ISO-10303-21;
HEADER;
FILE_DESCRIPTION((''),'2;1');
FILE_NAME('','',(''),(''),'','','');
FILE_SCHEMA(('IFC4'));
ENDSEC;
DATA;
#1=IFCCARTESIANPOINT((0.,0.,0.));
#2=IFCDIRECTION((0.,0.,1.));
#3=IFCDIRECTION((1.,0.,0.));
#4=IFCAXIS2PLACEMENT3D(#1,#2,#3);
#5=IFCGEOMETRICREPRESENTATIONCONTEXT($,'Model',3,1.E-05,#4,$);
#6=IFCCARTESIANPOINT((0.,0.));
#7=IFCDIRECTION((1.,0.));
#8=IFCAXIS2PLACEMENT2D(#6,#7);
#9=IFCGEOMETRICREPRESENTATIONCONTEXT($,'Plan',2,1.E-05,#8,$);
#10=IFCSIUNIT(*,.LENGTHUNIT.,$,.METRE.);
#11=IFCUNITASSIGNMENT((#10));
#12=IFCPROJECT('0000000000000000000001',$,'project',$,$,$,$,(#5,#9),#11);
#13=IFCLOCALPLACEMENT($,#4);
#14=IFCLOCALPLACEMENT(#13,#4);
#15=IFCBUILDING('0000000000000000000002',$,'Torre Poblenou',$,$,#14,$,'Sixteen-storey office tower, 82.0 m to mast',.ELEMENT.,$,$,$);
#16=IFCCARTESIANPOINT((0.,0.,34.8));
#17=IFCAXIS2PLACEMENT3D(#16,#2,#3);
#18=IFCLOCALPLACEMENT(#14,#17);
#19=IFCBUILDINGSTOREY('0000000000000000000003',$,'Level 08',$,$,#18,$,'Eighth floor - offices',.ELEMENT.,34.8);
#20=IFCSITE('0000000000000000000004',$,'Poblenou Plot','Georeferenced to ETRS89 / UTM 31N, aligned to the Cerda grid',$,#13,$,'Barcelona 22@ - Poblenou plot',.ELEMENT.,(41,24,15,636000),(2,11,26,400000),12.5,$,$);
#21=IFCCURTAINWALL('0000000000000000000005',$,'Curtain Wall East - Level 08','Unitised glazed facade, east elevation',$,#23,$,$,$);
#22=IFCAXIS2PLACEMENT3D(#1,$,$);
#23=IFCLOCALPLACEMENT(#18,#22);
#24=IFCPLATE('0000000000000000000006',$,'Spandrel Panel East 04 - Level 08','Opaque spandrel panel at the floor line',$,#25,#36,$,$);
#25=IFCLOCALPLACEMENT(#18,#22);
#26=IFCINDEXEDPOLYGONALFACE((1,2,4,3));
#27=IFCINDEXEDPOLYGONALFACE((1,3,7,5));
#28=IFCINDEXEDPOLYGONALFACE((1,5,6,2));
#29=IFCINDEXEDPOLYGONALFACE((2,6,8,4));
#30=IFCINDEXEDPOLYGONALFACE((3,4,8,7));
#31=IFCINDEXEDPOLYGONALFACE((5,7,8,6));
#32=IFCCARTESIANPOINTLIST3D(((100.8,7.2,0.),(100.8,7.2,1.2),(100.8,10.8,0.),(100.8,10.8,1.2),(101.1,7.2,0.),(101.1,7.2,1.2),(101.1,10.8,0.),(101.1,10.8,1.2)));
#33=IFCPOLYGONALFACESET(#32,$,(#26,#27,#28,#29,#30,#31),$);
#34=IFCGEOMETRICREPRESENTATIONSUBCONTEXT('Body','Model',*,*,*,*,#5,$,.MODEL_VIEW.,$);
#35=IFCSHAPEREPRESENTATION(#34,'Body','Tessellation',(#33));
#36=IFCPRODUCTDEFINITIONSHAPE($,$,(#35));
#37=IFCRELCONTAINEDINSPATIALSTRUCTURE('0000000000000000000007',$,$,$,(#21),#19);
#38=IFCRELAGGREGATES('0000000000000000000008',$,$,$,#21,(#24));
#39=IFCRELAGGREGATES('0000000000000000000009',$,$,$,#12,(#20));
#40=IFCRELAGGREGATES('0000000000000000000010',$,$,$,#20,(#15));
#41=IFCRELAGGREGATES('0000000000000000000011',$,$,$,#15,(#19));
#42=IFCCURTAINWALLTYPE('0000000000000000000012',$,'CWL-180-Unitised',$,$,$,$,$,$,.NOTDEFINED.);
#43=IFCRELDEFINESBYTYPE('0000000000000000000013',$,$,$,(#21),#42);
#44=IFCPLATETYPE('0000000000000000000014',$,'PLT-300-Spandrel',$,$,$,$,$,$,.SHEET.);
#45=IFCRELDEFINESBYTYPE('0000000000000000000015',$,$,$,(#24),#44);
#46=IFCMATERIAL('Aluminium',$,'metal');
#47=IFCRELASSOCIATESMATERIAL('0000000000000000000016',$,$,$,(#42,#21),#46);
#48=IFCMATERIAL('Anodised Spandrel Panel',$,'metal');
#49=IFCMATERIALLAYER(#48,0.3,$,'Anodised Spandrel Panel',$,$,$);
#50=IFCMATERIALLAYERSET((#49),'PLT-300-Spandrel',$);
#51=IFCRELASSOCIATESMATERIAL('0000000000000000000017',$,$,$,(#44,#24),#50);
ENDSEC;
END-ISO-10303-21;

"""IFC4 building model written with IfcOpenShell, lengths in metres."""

from ifc_helpers import new_model, si_unit, frame, origin_with_axes, origin_2d_with_axis, place, context, subcontext, project, spatial, line, indexed_curve, outline, extrude, material, layer, layer_set, layer_usage, type_object, element, aggregate, save


model = new_model("IFC4")

# Units and contexts
model_context = context("Model", 3, precision=1e-05, world=origin_with_axes())
plan_context = context("Plan", 2, precision=1e-05, world=origin_2d_with_axis())
body_context = subcontext(model_context, "Body", "Model", "MODEL_VIEW")
ifc_project = project(units=[si_unit("LENGTHUNIT", "METRE")], contexts=[model_context, plan_context])

# Site, building, storey
site_placement = place(None, origin_with_axes())
site = spatial("IfcSite", under=ifc_project, at=site_placement, Name="Poblenou Plot", Description="Georeferenced to ETRS89 / UTM 31N, aligned to the Cerda grid", LongName="Barcelona 22@ - Poblenou plot", CompositionType="ELEMENT", RefLatitude=(41, 24, 15, 636000), RefLongitude=(2, 11, 26, 400000), RefElevation=12.5)
building_placement = place(site_placement, origin_with_axes())
building = spatial("IfcBuilding", under=site, at=building_placement, Name="Torre Poblenou", LongName="Sixteen-storey office tower, 82.0 m to mast", CompositionType="ELEMENT")
storey_placement = place(building_placement, frame((0.0, 0.0, 34.8), z_axis=(0.0, 0.0, 1.0), x_axis=(1.0, 0.0, 0.0)))
storey = spatial("IfcBuildingStorey", under=building, at=storey_placement, Name="Level 08", LongName="Eighth floor - offices", CompositionType="ELEMENT", Elevation=34.8)

# Curtain wall
ifc_material_1 = material(Name="Aluminium", Category="metal")
curtain_wall_type = type_object("IfcCurtainWallType", Name="CWL-180-Unitised", PredefinedType="NOTDEFINED", material=ifc_material_1)
curtain_wall_1_placement = place(storey_placement, frame((100.8, 21.6, 0.0), z_axis=(0.0, 0.0, 1.0), x_axis=(0.0, -1.0, 0.0)))
curtain_wall_1 = element("IfcCurtainWall", 1, at=curtain_wall_1_placement, inside=storey, type_object=curtain_wall_type, material=ifc_material_1, Name="Curtain Wall East - Level 08", Description="Unitised glazed facade, east elevation")

# Plate
ifc_material_2 = material(Name="Anodised Spandrel Panel", Category="metal")
ifc_layer_1 = layer(ifc_material_2, 0.3, Name="Anodised Spandrel Panel")
ifc_layer_set_1 = layer_set([ifc_layer_1], Name="PLT-300-Spandrel")
plate_type_1 = type_object("IfcPlateType", Name="PLT-300-Spandrel", PredefinedType="SHEET", material=ifc_layer_set_1)
ifc_layer_usage_1 = layer_usage(ifc_layer_set_1, "AXIS2", "POSITIVE", 0.0)
plate_1_placement = place(curtain_wall_1_placement, frame((10.8, 0.0, 0.0), z_axis=(0.0, 0.0, 1.0), x_axis=(1.0, 0.0, 0.0)))
plate_1 = element("IfcPlate", 2, at=plate_1_placement, type_object=plate_type_1, material=ifc_layer_usage_1, Name="Spandrel Panel East 04 - Level 08", Description="Opaque spandrel panel at the floor line", context=body_context, shape_type="SweptSolid", body=[
    extrude(outline(indexed_curve([(0.0, 0.0), (3.6, 0.0), (3.6, 0.3), (0.0, 0.3)], segments=[line(1, 2, 3, 4, 1)])), origin_with_axes(), (0.0, 0.0, 1.0), 1.2),
])
aggregate(curtain_wall_1, [plate_1])

save(model, "model.ifc")
